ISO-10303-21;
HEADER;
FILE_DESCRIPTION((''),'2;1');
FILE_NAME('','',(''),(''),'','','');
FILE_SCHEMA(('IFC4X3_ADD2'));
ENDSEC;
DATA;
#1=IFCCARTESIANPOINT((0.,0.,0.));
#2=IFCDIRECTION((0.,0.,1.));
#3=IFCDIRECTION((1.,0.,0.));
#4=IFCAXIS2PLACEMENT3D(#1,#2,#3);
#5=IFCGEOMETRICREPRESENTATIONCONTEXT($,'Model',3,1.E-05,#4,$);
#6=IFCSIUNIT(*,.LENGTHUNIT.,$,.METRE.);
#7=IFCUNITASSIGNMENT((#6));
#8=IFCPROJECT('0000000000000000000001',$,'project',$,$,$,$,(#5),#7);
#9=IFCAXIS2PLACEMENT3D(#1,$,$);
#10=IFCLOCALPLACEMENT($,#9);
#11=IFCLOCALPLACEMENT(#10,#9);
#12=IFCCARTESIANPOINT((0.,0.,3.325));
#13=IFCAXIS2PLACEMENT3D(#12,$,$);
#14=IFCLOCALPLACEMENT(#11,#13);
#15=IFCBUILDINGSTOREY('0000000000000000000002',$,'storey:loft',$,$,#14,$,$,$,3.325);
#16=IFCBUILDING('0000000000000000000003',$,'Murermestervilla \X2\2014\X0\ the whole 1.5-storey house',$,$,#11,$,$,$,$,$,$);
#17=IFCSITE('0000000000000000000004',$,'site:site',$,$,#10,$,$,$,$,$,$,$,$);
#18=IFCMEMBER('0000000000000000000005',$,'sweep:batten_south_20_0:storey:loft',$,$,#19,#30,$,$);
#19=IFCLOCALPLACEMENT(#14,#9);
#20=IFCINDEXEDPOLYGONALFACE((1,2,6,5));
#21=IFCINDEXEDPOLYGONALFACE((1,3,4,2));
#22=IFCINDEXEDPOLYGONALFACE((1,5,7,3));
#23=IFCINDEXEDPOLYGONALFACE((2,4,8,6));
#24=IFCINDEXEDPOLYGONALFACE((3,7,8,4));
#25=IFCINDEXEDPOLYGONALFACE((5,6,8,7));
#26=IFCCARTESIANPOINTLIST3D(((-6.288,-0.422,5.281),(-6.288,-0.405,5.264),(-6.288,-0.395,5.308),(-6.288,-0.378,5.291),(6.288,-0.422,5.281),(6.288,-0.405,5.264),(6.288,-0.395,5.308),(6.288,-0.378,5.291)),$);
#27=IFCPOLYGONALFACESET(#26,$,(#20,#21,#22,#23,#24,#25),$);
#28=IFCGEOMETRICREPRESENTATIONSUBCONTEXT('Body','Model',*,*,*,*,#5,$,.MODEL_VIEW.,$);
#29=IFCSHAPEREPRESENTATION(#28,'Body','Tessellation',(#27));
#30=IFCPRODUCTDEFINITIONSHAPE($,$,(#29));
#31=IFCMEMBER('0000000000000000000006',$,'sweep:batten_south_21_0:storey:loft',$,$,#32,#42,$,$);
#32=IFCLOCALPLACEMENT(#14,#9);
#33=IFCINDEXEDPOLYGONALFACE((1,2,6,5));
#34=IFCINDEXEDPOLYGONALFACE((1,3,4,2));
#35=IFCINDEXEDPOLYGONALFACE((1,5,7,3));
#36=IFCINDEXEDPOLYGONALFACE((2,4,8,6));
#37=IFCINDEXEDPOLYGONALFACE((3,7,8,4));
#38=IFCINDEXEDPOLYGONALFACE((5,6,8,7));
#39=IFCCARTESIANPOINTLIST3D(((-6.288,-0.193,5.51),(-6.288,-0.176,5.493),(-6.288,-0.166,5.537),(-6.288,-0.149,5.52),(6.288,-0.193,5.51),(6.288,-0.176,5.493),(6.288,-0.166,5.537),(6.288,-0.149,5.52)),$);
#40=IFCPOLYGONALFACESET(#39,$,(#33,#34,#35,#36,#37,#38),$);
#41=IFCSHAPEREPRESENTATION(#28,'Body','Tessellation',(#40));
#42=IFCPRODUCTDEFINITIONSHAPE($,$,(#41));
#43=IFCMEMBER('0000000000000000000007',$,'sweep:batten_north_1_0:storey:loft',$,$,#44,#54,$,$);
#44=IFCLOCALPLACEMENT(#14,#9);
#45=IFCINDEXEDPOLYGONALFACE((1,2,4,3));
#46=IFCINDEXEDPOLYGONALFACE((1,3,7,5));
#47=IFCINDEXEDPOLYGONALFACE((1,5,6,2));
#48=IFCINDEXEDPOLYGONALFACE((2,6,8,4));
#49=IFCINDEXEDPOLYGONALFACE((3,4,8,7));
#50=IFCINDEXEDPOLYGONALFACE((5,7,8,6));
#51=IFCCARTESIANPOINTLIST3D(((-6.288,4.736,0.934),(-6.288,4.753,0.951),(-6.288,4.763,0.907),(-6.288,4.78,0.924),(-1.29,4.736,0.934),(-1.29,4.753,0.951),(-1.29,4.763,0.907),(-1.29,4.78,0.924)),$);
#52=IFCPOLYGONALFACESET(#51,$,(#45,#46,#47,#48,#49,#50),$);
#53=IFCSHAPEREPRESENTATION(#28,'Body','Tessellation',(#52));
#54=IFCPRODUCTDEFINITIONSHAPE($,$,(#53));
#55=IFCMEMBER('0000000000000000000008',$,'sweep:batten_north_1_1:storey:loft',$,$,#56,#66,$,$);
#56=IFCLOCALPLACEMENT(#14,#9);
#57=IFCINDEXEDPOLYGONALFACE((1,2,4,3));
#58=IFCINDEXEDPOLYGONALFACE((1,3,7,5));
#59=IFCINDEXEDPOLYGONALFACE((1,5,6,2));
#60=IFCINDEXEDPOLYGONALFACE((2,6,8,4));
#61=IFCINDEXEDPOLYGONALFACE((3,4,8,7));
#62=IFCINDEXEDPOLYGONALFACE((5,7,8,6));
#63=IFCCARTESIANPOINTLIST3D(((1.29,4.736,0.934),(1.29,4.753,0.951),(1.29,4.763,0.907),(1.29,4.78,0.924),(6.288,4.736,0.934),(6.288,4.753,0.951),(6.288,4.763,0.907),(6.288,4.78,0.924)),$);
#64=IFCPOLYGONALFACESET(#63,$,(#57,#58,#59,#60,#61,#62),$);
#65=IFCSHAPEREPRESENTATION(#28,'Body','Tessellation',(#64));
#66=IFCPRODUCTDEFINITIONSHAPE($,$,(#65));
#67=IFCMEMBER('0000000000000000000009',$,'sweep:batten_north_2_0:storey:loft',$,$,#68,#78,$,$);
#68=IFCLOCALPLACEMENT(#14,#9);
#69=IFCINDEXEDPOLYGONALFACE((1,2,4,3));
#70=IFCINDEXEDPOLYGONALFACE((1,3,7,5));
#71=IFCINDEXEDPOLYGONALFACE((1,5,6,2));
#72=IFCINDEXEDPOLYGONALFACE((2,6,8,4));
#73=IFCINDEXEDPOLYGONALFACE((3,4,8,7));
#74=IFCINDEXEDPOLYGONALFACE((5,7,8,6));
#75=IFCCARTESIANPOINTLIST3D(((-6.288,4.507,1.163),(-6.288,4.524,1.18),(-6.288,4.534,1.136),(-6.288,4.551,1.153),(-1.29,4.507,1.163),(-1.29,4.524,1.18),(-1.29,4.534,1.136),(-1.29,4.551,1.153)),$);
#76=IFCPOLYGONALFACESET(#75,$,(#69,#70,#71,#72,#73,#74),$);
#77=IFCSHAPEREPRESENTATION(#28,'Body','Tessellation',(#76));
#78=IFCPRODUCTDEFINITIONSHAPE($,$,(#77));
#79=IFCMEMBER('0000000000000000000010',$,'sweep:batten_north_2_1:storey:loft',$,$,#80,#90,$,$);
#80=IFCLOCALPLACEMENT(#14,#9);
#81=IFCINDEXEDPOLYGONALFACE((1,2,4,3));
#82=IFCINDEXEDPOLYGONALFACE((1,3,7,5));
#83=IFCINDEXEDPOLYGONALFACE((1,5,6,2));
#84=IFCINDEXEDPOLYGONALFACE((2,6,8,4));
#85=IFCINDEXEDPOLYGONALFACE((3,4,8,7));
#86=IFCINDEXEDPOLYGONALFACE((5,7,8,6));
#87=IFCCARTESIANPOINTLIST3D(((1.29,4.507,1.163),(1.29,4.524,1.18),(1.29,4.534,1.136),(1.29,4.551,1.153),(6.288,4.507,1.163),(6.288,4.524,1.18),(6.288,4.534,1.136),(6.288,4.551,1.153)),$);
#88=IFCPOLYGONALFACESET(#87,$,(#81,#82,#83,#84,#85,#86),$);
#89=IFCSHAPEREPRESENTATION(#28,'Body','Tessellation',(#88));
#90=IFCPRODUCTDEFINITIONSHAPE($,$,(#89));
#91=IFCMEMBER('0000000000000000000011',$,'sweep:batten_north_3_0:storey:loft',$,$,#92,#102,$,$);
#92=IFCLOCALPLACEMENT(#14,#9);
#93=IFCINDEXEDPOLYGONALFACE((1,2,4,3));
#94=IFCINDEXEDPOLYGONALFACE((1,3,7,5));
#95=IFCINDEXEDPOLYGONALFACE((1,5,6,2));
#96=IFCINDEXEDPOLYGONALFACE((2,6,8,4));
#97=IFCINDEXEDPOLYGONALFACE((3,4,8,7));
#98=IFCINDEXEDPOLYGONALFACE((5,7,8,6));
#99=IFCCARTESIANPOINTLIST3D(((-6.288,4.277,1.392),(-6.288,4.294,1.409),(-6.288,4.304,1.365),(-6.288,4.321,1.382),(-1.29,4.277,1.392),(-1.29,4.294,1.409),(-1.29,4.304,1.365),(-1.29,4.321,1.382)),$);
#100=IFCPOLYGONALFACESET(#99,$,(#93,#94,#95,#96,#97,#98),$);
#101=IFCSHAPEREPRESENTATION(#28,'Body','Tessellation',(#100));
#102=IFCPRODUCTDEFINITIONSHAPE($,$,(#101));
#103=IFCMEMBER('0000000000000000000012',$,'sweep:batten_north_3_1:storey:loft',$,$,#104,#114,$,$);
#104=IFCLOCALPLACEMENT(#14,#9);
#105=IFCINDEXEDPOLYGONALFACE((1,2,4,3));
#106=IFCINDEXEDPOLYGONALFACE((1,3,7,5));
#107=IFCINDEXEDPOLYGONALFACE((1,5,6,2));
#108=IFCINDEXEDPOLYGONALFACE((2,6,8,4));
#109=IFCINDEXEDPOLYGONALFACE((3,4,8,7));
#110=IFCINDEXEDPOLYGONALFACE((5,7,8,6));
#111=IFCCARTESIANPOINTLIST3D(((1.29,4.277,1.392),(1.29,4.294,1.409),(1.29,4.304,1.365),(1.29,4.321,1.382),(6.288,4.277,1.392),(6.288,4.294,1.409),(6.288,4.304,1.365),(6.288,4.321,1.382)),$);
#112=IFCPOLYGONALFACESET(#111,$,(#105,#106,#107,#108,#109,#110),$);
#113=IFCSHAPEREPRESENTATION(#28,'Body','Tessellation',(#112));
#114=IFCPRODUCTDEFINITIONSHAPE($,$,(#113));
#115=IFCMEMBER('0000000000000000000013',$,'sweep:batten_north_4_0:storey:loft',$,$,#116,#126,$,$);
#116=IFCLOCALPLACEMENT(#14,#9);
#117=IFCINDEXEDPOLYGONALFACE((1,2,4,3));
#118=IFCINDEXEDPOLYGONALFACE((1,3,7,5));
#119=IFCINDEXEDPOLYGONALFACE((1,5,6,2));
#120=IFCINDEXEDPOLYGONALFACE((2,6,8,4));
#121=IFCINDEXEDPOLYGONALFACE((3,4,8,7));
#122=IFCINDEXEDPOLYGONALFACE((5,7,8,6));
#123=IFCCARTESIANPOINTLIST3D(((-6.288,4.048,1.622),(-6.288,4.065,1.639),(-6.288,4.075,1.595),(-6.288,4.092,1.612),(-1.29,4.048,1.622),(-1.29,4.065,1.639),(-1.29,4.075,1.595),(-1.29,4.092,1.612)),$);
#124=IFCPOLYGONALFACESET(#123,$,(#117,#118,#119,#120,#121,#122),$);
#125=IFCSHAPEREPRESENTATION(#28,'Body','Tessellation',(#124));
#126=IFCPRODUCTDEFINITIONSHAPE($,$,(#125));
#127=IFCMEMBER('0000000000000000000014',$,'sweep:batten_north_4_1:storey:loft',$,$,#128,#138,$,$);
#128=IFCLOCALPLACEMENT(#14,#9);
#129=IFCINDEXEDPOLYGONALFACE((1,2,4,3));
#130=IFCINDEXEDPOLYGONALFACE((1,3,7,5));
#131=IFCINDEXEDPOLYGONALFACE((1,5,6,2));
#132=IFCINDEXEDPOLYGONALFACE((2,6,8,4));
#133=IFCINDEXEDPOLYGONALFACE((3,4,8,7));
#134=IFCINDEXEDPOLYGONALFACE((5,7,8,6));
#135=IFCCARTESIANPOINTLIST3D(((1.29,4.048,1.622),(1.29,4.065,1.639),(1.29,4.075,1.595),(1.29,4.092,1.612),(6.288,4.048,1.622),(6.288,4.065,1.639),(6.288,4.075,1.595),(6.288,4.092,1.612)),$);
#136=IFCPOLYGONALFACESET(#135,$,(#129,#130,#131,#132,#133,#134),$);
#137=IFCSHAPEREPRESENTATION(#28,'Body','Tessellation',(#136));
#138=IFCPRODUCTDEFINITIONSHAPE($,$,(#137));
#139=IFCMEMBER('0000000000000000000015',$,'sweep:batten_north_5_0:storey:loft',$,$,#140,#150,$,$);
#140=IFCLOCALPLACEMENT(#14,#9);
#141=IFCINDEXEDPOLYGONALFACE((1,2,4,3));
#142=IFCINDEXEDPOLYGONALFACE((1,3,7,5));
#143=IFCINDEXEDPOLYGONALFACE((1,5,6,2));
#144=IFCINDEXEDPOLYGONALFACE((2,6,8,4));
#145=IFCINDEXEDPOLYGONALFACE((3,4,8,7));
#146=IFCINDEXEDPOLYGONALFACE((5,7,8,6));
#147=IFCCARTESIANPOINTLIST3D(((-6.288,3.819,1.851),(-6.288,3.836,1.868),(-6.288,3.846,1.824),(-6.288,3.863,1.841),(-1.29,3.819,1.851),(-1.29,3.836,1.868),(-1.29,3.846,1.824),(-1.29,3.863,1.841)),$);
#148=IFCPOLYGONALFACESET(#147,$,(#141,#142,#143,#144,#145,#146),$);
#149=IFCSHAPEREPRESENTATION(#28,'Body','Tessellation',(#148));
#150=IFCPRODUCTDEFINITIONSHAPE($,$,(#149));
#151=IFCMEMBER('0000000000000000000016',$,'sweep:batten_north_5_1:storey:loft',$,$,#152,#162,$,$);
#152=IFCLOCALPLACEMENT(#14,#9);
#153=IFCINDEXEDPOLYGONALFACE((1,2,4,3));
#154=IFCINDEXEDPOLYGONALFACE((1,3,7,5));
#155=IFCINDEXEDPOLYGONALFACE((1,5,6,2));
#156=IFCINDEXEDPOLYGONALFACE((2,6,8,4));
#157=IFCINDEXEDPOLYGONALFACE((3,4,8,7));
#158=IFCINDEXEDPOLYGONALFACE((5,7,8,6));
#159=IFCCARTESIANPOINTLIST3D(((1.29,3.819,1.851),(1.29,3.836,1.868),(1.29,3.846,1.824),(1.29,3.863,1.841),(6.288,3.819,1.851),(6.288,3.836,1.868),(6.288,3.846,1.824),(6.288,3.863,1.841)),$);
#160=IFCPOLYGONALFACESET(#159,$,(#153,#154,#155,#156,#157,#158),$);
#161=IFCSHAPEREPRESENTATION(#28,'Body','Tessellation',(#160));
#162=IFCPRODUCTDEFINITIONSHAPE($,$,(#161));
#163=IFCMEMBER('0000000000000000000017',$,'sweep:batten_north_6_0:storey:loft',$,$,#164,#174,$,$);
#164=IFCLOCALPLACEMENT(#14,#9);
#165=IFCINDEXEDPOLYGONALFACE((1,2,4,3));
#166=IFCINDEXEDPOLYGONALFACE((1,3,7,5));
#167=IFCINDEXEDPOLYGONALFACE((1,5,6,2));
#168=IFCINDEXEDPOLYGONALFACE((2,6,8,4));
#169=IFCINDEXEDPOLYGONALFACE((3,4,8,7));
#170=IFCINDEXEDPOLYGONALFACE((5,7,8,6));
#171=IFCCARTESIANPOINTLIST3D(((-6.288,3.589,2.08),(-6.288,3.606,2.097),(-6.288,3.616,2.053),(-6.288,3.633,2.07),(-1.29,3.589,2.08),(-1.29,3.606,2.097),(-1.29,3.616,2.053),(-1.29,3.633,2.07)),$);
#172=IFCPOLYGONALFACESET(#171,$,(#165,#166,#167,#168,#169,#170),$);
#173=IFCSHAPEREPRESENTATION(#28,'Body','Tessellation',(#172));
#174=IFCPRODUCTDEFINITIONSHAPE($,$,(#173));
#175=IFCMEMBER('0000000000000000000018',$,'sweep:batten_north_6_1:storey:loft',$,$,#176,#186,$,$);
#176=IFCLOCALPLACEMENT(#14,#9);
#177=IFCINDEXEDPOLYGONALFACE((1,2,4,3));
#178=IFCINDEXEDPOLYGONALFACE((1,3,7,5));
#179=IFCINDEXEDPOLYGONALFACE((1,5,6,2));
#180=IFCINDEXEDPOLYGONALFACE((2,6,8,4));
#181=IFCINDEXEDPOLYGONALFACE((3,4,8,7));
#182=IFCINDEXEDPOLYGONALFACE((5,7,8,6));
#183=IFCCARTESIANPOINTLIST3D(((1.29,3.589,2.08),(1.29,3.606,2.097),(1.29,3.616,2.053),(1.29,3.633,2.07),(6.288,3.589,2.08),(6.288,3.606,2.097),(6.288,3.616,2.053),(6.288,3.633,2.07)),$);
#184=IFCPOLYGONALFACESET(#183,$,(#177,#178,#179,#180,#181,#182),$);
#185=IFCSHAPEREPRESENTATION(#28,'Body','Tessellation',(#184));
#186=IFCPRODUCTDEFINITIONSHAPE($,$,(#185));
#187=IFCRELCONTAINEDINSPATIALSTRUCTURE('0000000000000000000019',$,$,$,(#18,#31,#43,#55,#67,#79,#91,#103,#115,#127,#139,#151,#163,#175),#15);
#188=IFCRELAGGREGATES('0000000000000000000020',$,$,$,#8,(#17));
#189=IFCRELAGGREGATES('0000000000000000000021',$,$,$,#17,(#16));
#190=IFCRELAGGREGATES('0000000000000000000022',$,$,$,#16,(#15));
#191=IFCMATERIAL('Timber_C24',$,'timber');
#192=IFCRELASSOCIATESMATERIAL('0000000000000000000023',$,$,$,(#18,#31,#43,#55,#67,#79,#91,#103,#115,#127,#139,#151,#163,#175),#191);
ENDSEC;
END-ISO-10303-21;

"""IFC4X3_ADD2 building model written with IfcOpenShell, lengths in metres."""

from ifc_helpers import new_model, si_unit, frame, origin, origin_with_axes, place, context, subcontext, project, spatial, polyline, outline, extrude, material, element, save


model = new_model("IFC4X3_ADD2")

# Units and contexts
model_context = context("Model", 3, precision=1e-05, world=origin_with_axes())
body_context = subcontext(model_context, "Body", "Model", "MODEL_VIEW")
ifc_project = project(units=[si_unit("LENGTHUNIT", "METRE")], contexts=[model_context])

# Site, building, storey
site_placement = place(None, origin())
site = spatial("IfcSite", under=ifc_project, at=site_placement, Name="site:site")
building_placement = place(site_placement, origin())
building = spatial("IfcBuilding", under=site, at=building_placement, Name="Murermestervilla — the whole 1.5-storey house")
storey_placement = place(building_placement, frame((0.0, 0.0, 3.325)))
storey = spatial("IfcBuildingStorey", under=building, at=storey_placement, Name="storey:loft", Elevation=3.325)

# Members
ifc_material = material(Name="Timber_C24", Category="timber")
placement = place(storey_placement, frame((0.0, 0.0, -3.325)))
element("IfcMember", 1, at=placement, inside=storey, material=ifc_material, Name="sweep:batten_south_20_0:storey:loft", context=body_context, shape_type="SweptSolid", body=[
    extrude(outline(polyline([(-0.005, -0.022), (0.022, 0.005), (0.005, 0.022), (-0.022, -0.005), (-0.005, -0.022)])), frame((-6.288, -0.4, 8.611), z_axis=(1.0, 0.0, 0.0), x_axis=(0.0, 1.0, 0.0)), (0.0, 0.0, 1.0), 12.576),
])
element("IfcMember", 2, at=placement, inside=storey, material=ifc_material, Name="sweep:batten_south_21_0:storey:loft", context=body_context, shape_type="SweptSolid", body=[
    extrude(outline(polyline([(-0.005, -0.022), (0.022, 0.005), (0.005, 0.022), (-0.022, -0.005), (-0.005, -0.022)])), frame((-6.288, -0.171, 8.84), z_axis=(1.0, 0.0, 0.0), x_axis=(0.0, 1.0, 0.0)), (0.0, 0.0, 1.0), 12.576),
])
element("IfcMember", 3, at=placement, inside=storey, material=ifc_material, Name="sweep:batten_north_1_0:storey:loft", context=body_context, shape_type="SweptSolid", body=[
    extrude(outline(polyline([(0.022, -0.005), (-0.005, 0.022), (-0.022, 0.005), (0.005, -0.022), (0.022, -0.005)])), frame((-6.288, 4.758, 4.254), z_axis=(1.0, 0.0, 0.0), x_axis=(0.0, 1.0, 0.0)), (0.0, 0.0, 1.0), 4.998),
])
element("IfcMember", 4, at=placement, inside=storey, material=ifc_material, Name="sweep:batten_north_1_1:storey:loft", context=body_context, shape_type="SweptSolid", body=[
    extrude(outline(polyline([(0.022, -0.005), (-0.005, 0.022), (-0.022, 0.005), (0.005, -0.022), (0.022, -0.005)])), frame((1.29, 4.758, 4.254), z_axis=(1.0, 0.0, 0.0), x_axis=(0.0, 1.0, 0.0)), (0.0, 0.0, 1.0), 4.998),
])
element("IfcMember", 5, at=placement, inside=storey, material=ifc_material, Name="sweep:batten_north_2_0:storey:loft", context=body_context, shape_type="SweptSolid", body=[
    extrude(outline(polyline([(0.022, -0.005), (-0.005, 0.022), (-0.022, 0.005), (0.005, -0.022), (0.022, -0.005)])), frame((-6.288, 4.529, 4.483), z_axis=(1.0, 0.0, 0.0), x_axis=(0.0, 1.0, 0.0)), (0.0, 0.0, 1.0), 4.998),
])
element("IfcMember", 6, at=placement, inside=storey, material=ifc_material, Name="sweep:batten_north_2_1:storey:loft", context=body_context, shape_type="SweptSolid", body=[
    extrude(outline(polyline([(0.022, -0.005), (-0.005, 0.022), (-0.022, 0.005), (0.005, -0.022), (0.022, -0.005)])), frame((1.29, 4.529, 4.483), z_axis=(1.0, 0.0, 0.0), x_axis=(0.0, 1.0, 0.0)), (0.0, 0.0, 1.0), 4.998),
])
element("IfcMember", 7, at=placement, inside=storey, material=ifc_material, Name="sweep:batten_north_3_0:storey:loft", context=body_context, shape_type="SweptSolid", body=[
    extrude(outline(polyline([(0.022, -0.005), (-0.005, 0.022), (-0.022, 0.005), (0.005, -0.022), (0.022, -0.005)])), frame((-6.288, 4.299, 4.712), z_axis=(1.0, 0.0, 0.0), x_axis=(0.0, 1.0, 0.0)), (0.0, 0.0, 1.0), 4.998),
])
element("IfcMember", 8, at=placement, inside=storey, material=ifc_material, Name="sweep:batten_north_3_1:storey:loft", context=body_context, shape_type="SweptSolid", body=[
    extrude(outline(polyline([(0.022, -0.005), (-0.005, 0.022), (-0.022, 0.005), (0.005, -0.022), (0.022, -0.005)])), frame((1.29, 4.299, 4.712), z_axis=(1.0, 0.0, 0.0), x_axis=(0.0, 1.0, 0.0)), (0.0, 0.0, 1.0), 4.998),
])
element("IfcMember", 9, at=placement, inside=storey, material=ifc_material, Name="sweep:batten_north_4_0:storey:loft", context=body_context, shape_type="SweptSolid", body=[
    extrude(outline(polyline([(0.022, -0.005), (-0.005, 0.022), (-0.022, 0.005), (0.005, -0.022), (0.022, -0.005)])), frame((-6.288, 4.07, 4.942), z_axis=(1.0, 0.0, 0.0), x_axis=(0.0, 1.0, 0.0)), (0.0, 0.0, 1.0), 4.998),
])
element("IfcMember", 10, at=placement, inside=storey, material=ifc_material, Name="sweep:batten_north_4_1:storey:loft", context=body_context, shape_type="SweptSolid", body=[
    extrude(outline(polyline([(0.022, -0.005), (-0.005, 0.022), (-0.022, 0.005), (0.005, -0.022), (0.022, -0.005)])), frame((1.29, 4.07, 4.942), z_axis=(1.0, 0.0, 0.0), x_axis=(0.0, 1.0, 0.0)), (0.0, 0.0, 1.0), 4.998),
])
element("IfcMember", 11, at=placement, inside=storey, material=ifc_material, Name="sweep:batten_north_5_0:storey:loft", context=body_context, shape_type="SweptSolid", body=[
    extrude(outline(polyline([(0.022, -0.005), (-0.005, 0.022), (-0.022, 0.005), (0.005, -0.022), (0.022, -0.005)])), frame((-6.288, 3.841, 5.171), z_axis=(1.0, 0.0, 0.0), x_axis=(0.0, 1.0, 0.0)), (0.0, 0.0, 1.0), 4.998),
])
element("IfcMember", 12, at=placement, inside=storey, material=ifc_material, Name="sweep:batten_north_5_1:storey:loft", context=body_context, shape_type="SweptSolid", body=[
    extrude(outline(polyline([(0.022, -0.005), (-0.005, 0.022), (-0.022, 0.005), (0.005, -0.022), (0.022, -0.005)])), frame((1.29, 3.841, 5.171), z_axis=(1.0, 0.0, 0.0), x_axis=(0.0, 1.0, 0.0)), (0.0, 0.0, 1.0), 4.998),
])
element("IfcMember", 13, at=placement, inside=storey, material=ifc_material, Name="sweep:batten_north_6_0:storey:loft", context=body_context, shape_type="SweptSolid", body=[
    extrude(outline(polyline([(0.022, -0.005), (-0.005, 0.022), (-0.022, 0.005), (0.005, -0.022), (0.022, -0.005)])), frame((-6.288, 3.611, 5.4), z_axis=(1.0, 0.0, 0.0), x_axis=(0.0, 1.0, 0.0)), (0.0, 0.0, 1.0), 4.998),
])
element("IfcMember", 14, at=placement, inside=storey, material=ifc_material, Name="sweep:batten_north_6_1:storey:loft", context=body_context, shape_type="SweptSolid", body=[
    extrude(outline(polyline([(0.022, -0.005), (-0.005, 0.022), (-0.022, 0.005), (0.005, -0.022), (0.022, -0.005)])), frame((1.29, 3.611, 5.4), z_axis=(1.0, 0.0, 0.0), x_axis=(0.0, 1.0, 0.0)), (0.0, 0.0, 1.0), 4.998),
])

save(model, "model.ifc")
